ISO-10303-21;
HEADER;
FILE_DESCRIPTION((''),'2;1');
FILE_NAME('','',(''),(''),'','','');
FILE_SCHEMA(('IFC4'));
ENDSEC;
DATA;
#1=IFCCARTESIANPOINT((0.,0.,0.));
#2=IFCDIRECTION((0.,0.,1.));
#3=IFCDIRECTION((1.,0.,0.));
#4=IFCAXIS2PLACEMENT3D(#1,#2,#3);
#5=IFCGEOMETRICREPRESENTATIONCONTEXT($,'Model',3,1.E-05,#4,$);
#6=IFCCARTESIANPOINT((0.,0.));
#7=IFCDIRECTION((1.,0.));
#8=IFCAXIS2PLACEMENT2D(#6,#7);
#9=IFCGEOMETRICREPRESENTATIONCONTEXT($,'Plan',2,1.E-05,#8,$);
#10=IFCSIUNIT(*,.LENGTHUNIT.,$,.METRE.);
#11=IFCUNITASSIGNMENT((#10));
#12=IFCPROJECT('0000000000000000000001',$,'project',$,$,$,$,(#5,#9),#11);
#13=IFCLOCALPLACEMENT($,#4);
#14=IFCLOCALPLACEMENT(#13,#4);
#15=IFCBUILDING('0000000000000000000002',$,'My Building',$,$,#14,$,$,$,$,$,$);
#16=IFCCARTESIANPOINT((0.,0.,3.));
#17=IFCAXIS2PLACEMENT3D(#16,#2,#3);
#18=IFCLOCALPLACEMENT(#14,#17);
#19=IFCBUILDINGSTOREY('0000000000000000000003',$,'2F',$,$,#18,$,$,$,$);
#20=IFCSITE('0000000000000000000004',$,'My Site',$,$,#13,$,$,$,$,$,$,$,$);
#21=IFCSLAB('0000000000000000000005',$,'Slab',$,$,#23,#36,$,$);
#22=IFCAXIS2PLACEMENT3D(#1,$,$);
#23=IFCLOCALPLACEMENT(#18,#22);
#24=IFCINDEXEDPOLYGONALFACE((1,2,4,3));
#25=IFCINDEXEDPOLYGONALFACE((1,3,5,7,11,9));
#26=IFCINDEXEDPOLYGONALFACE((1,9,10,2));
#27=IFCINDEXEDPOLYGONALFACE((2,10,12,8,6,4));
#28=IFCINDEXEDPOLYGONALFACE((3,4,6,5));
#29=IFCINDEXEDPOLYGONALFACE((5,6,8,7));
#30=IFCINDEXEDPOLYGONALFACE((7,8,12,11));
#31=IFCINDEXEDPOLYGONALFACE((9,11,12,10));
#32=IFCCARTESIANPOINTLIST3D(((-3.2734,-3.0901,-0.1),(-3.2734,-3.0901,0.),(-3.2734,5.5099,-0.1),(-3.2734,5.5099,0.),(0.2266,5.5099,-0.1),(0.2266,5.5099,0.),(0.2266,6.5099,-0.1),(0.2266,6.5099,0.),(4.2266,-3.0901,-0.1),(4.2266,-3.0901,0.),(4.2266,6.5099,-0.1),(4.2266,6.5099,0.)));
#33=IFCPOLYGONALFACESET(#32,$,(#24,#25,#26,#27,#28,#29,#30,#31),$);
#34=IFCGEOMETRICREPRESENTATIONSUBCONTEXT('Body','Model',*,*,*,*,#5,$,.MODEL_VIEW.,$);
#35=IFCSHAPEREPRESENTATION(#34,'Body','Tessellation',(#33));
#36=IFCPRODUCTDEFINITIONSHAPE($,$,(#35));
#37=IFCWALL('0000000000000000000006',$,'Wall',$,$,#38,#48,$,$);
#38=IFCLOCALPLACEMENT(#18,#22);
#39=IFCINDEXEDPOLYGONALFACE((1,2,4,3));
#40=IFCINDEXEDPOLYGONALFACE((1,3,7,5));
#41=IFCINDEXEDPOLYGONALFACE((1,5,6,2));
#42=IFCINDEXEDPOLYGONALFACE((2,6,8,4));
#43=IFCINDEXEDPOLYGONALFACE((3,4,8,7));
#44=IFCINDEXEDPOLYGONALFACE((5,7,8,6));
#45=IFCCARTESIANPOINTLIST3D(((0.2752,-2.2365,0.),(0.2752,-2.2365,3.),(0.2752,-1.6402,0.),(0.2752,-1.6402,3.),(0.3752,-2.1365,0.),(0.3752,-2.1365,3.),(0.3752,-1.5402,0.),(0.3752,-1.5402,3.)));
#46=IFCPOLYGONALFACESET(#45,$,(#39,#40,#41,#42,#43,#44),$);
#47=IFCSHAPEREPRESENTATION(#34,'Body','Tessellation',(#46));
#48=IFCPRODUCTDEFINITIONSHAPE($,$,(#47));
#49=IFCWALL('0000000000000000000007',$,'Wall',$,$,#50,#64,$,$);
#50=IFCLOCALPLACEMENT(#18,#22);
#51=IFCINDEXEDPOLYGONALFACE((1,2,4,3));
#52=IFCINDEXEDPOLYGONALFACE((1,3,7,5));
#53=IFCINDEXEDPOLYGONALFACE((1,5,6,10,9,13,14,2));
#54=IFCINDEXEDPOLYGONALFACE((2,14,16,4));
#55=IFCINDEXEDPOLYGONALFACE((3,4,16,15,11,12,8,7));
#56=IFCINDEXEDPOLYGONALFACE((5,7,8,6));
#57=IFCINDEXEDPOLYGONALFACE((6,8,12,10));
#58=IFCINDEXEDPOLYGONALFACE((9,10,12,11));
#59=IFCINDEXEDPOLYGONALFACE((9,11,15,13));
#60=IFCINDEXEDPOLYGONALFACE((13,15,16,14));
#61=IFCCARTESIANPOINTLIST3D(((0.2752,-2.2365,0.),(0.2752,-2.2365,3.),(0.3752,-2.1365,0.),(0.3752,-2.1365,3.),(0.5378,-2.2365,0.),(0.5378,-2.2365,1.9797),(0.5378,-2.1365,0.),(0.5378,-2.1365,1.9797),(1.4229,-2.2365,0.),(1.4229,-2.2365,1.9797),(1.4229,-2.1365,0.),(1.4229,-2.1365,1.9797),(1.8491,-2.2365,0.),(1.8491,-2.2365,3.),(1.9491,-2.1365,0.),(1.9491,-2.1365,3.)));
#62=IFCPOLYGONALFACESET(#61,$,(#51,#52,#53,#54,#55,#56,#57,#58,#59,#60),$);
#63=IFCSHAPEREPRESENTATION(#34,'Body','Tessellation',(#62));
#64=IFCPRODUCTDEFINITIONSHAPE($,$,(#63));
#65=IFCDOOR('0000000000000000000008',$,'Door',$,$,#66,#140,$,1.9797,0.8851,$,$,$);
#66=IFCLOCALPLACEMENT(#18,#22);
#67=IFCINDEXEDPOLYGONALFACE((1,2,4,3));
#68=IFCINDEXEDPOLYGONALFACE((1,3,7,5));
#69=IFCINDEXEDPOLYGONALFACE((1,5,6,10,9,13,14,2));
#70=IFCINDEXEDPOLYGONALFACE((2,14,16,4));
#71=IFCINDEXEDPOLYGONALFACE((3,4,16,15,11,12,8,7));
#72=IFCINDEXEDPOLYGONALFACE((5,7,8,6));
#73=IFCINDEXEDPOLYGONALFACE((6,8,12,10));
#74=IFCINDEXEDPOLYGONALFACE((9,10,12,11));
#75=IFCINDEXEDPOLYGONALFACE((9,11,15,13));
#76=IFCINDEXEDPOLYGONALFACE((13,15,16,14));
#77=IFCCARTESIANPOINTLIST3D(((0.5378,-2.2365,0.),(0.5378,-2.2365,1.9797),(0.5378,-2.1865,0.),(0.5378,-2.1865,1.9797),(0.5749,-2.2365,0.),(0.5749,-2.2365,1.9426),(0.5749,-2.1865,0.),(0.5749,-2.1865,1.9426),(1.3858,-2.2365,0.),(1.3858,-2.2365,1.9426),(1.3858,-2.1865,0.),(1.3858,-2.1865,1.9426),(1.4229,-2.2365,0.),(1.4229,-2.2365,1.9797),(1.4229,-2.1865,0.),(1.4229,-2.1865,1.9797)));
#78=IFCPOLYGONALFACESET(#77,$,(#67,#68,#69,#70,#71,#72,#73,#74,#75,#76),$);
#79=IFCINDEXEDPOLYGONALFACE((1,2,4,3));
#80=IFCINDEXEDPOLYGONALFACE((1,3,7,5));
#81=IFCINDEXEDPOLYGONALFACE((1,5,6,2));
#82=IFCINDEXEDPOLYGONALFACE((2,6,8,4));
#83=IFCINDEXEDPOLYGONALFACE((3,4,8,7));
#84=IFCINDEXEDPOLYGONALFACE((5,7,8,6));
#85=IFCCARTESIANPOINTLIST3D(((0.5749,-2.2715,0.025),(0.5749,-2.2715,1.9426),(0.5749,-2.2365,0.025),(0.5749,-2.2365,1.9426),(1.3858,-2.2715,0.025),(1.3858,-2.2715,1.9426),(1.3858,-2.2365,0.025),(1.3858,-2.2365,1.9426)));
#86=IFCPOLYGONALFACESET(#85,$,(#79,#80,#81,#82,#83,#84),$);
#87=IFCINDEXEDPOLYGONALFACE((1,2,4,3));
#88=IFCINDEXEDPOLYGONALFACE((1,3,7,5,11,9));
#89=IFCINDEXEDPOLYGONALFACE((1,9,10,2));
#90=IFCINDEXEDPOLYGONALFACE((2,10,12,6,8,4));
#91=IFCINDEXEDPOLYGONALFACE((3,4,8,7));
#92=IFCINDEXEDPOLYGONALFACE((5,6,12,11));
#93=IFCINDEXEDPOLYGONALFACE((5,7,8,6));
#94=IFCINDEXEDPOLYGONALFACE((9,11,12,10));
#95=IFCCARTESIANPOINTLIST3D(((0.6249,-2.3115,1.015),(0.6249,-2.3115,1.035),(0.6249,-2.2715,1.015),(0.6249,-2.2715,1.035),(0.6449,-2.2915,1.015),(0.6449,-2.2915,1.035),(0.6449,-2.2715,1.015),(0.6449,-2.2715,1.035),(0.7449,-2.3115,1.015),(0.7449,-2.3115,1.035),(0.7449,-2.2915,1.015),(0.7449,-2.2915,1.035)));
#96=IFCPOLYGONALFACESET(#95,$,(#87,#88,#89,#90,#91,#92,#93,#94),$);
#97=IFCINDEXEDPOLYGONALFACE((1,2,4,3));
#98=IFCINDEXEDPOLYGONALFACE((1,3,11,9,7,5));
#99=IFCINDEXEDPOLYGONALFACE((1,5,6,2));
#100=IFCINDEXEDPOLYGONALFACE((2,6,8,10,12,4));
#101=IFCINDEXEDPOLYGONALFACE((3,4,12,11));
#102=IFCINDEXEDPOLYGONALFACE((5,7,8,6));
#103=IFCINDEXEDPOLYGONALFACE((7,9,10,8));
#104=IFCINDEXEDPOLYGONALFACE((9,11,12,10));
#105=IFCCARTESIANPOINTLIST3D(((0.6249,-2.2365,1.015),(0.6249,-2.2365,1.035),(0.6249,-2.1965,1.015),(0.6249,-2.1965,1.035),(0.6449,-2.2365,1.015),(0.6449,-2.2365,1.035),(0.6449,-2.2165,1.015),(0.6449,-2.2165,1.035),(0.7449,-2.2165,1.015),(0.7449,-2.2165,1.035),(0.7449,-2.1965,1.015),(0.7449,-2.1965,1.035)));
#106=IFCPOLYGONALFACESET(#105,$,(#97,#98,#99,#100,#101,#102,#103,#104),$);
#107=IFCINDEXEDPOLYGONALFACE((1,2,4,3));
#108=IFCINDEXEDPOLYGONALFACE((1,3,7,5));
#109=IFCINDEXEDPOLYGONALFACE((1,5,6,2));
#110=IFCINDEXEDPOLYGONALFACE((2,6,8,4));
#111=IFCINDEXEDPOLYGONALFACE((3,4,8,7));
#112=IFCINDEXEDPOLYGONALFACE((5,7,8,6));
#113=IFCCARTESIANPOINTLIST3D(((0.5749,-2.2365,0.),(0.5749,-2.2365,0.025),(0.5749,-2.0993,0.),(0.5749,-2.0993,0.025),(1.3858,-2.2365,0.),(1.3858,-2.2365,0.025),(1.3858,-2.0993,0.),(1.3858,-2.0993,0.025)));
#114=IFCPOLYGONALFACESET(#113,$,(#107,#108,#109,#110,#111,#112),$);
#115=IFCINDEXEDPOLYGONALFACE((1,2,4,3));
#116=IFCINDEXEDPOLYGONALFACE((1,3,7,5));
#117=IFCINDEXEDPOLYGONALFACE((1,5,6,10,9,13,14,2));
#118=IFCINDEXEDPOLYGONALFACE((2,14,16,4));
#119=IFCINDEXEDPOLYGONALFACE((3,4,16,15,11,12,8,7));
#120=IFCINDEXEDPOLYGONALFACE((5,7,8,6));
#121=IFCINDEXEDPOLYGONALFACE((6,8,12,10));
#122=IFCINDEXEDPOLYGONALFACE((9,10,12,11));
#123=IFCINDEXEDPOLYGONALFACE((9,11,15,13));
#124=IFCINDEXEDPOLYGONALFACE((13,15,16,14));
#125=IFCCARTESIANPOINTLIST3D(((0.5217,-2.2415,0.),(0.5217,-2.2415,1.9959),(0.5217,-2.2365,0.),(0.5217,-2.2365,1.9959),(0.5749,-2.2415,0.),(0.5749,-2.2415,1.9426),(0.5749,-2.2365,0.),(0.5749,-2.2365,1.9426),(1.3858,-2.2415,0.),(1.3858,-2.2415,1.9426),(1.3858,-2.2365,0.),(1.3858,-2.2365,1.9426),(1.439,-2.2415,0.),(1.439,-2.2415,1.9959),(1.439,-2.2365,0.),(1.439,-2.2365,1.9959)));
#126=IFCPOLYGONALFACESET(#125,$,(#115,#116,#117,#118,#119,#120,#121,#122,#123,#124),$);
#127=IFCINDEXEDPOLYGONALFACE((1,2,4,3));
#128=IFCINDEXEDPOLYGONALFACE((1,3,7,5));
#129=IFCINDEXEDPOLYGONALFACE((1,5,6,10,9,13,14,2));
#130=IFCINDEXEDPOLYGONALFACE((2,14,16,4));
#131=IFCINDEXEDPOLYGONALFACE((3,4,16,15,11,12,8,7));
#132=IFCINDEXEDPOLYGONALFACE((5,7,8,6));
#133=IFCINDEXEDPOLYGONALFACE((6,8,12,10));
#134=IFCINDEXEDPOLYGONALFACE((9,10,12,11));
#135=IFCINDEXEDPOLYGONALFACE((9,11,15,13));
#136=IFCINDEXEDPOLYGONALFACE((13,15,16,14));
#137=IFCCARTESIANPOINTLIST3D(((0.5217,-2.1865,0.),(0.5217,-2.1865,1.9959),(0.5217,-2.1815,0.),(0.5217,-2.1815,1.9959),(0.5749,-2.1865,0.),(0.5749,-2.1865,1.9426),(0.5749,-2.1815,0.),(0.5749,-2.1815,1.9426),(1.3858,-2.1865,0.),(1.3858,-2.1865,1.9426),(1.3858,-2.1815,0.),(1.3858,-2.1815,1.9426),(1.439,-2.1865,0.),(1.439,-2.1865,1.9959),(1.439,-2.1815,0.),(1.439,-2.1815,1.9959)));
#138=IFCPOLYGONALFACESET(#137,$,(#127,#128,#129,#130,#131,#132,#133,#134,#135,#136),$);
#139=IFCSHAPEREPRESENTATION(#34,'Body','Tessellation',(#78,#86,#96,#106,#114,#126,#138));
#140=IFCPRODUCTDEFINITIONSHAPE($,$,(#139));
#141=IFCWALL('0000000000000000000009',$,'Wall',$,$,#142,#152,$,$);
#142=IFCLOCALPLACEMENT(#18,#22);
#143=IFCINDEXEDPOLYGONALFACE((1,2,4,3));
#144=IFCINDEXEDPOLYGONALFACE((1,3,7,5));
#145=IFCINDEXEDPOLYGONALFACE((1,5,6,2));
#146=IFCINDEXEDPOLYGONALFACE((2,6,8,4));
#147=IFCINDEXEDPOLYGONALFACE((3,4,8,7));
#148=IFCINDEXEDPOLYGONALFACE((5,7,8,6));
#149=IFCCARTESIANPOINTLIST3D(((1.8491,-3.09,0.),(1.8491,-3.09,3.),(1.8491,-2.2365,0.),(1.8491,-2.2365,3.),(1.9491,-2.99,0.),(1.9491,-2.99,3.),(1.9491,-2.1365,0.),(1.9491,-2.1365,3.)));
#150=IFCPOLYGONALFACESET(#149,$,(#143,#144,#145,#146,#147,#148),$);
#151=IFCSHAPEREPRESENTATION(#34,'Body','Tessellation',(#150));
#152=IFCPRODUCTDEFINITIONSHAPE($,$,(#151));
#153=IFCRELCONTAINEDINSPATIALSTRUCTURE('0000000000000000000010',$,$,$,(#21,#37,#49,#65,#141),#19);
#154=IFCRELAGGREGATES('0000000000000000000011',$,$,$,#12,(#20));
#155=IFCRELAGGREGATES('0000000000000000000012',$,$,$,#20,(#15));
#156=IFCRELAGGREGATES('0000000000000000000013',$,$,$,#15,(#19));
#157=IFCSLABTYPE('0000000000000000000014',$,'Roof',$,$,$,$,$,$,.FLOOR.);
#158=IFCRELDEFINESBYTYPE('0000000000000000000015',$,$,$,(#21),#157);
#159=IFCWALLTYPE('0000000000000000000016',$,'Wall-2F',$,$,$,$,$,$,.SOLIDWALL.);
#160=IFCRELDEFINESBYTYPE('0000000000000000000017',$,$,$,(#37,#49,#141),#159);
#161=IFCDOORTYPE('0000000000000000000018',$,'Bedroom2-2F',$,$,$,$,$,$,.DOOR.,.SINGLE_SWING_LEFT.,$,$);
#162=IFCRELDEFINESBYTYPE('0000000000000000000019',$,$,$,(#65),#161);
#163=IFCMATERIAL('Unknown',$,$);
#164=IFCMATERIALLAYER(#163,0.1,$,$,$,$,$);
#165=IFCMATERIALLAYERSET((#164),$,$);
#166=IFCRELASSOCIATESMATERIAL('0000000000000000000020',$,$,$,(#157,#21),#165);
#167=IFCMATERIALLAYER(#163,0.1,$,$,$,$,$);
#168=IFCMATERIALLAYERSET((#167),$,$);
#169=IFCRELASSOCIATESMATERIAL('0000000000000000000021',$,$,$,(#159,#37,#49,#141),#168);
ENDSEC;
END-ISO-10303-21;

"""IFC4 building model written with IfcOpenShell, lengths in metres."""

from ifc_helpers import new_model, entity, si_unit, frame, origin_with_axes, origin_2d_with_axis, place, context, subcontext, project, spatial, line, indexed_curve, outline, extrude, shape, source, transform, mapped, material, layer, layer_set, layer_usage, type_object, type_shapes, element, fill, save


model = new_model("IFC4")

# Units and contexts
model_context = context("Model", 3, precision=1e-05, world=origin_with_axes())
plan_context = context("Plan", 2, precision=1e-05, world=origin_2d_with_axis())
body_context_1 = subcontext(model_context, "Body", "Model", "MODEL_VIEW")
body_context_2 = subcontext(plan_context, "Body", "Plan", "PLAN_VIEW")
ifc_project = project(units=[si_unit("LENGTHUNIT", "METRE")], contexts=[model_context, plan_context])

# Site, building, storey
site_placement = place(None, origin_with_axes())
site = spatial("IfcSite", under=ifc_project, at=site_placement, Name="My Site")
building_placement = place(site_placement, origin_with_axes())
building = spatial("IfcBuilding", under=site, at=building_placement, Name="My Building")
storey_placement = place(building_placement, frame((0.0, 0.0, 3.0), z_axis=(0.0, 0.0, 1.0), x_axis=(1.0, 0.0, 0.0)))
storey = spatial("IfcBuildingStorey", under=building, at=storey_placement, Name="2F")

# Slab
ifc_material = material(Name="Unknown")
ifc_layer_1 = layer(ifc_material, 0.1)
ifc_layer_set_1 = layer_set([ifc_layer_1])
ifc_layer_usage_1 = layer_usage(ifc_layer_set_1, "AXIS3", "POSITIVE", -0.1)
slab_type = type_object("IfcSlabType", Name="Roof", PredefinedType="FLOOR", material=ifc_layer_set_1)
slab_placement = place(storey_placement, frame((4.2266, 6.5099, 0.0), z_axis=(0.0, 0.0, 1.0), x_axis=(1.0, 0.0, 0.0)))
element("IfcSlab", 1, at=slab_placement, inside=storey, type_object=slab_type, material=ifc_layer_usage_1, Name="Slab", context=body_context_1, shape_type="SweptSolid", body=[
    extrude(outline(indexed_curve([(0.0, 0.0), (-4.0, 0.0), (-4.0, -1.0), (-7.5, -1.0), (-7.5, -9.6), (0.0, -9.6), (0.0, 0.0)])), frame((0.0, 0.0, -0.1), z_axis=(0.0, 0.0, 1.0), x_axis=(1.0, 0.0, 0.0)), (0.0, 0.0, 1.0), 0.1),
])

# Wall
ifc_layer_2 = layer(ifc_material, 0.1)
ifc_layer_set_2 = layer_set([ifc_layer_2])
ifc_layer_usage_2 = layer_usage(ifc_layer_set_2, "AXIS2", "POSITIVE", 0.0)
wall_type = type_object("IfcWallType", Name="Wall-2F", PredefinedType="SOLIDWALL", material=ifc_layer_set_2)
wall_1_placement = place(storey_placement, frame((0.2752, -1.6402, 0.0), z_axis=(0.0, 0.0, 1.0), x_axis=(0.0, -1.0, 0.0)))
element("IfcWall", 2, at=wall_1_placement, inside=storey, type_object=wall_type, material=ifc_layer_usage_2, Name="Wall", context=body_context_1, shape_type="SweptSolid", body=[
    extrude(outline(indexed_curve([(0.0, 0.0), (-0.1, 0.1), (0.4963, 0.1), (0.5963, 0.0)], segments=[line(1, 2, 3, 4, 1)])), origin_with_axes(), (0.0, 0.0, 1.0), 3.0),
])

# Wall, opening, door
ifc_layer_usage_3 = layer_usage(ifc_layer_set_2, "AXIS2", "POSITIVE", 0.0)
wall_2_placement = place(storey_placement, frame((0.2752, -2.2365, 0.0), z_axis=(0.0, 0.0, 1.0), x_axis=(1.0, 0.0, 0.0)))
wall_2 = element("IfcWall", 3, at=wall_2_placement, inside=storey, type_object=wall_type, material=ifc_layer_usage_3, Name="Wall", context=body_context_1, shape_type="SweptSolid", body=[
    extrude(outline(indexed_curve([(0.0, 0.0), (0.1, 0.1), (1.6739, 0.1), (1.5739, 0.0)], segments=[line(1, 2, 3, 4, 1)])), origin_with_axes(), (0.0, 0.0, 1.0), 3.0),
])
shared_shape_1 = source(origin_with_axes(), body_context_1, "Body", "SweptSolid", [
    extrude(outline(indexed_curve([(0.0, 0.0), (0.8851, 0.0), (0.8851, 1.9797), (0.0, 1.9797)], segments=[line(1, 2, 3, 4, 1)])), frame((0.0, -0.6, 0.0), z_axis=(0.0, -1.0, 0.0), x_axis=(1.0, 0.0, 0.0)), (0.0, 0.0, -1.0), 1.2),
])
opening_1_placement = place(wall_2_placement, frame((0.2627, 0.0, 0.0), z_axis=(0.0, 0.0, 1.0), x_axis=(1.0, 0.0, 0.0)))
opening_1 = element("IfcOpeningElement", 4, at=opening_1_placement, cuts=wall_2, PredefinedType="OPENING", context=body_context_1, shape_type="MappedRepresentation", body=[
    mapped(shared_shape_1, transform((0.0, 0.0, 0.0), x_axis=(1.0, 0.0, 0.0), y_axis=(0.0, 1.0, 0.0), z_axis=(0.0, 0.0, 1.0), scale=1.0)),
])
door_type_1 = type_object("IfcDoorType", Name="Bedroom2-2F", OperationType="SINGLE_SWING_LEFT", PredefinedType="DOOR")
shared_shape_2 = source(origin_with_axes(), body_context_1, "Body", "SweptSolid", [
    extrude(outline(indexed_curve([(0.0, 0.0), (0.0, 1.9797), (0.8851, 1.9797), (0.8851, 0.0), (0.848, 0.0), (0.848, 1.9426), (0.0371, 1.9426), (0.0371, 0.0)], segments=[line(1, 2, 3, 4, 5, 6, 7, 8, 1)])), frame((0.0, 0.0, 0.0), z_axis=(0.0, -1.0, 0.0), x_axis=(1.0, 0.0, 0.0)), (0.0, 0.0, -1.0), 0.05),
    extrude(outline(indexed_curve([(0.0, 0.0), (0.8109, 0.0), (0.8109, 0.035), (0.0, 0.035)], segments=[line(1, 2, 3, 4, 1)])), frame((0.0371, -0.035, 0.025), z_axis=(0.0, 0.0, 1.0), x_axis=(1.0, 0.0, 0.0)), (0.0, 0.0, 1.0), 1.9176),
    extrude(outline(indexed_curve([(0.0, 0.0), (0.0, -0.04), (0.12, -0.04), (0.12, -0.02), (0.02, -0.02), (0.02, 0.0)], segments=[line(1, 2, 3, 4, 5, 6, 1)])), frame((0.0871, -0.035, 1.015), z_axis=(0.0, 0.0, 1.0), x_axis=(1.0, 0.0, 0.0)), (0.0, 0.0, 1.0), 0.02),
    extrude(outline(indexed_curve([(0.0, 0.0), (0.0, 0.04), (0.12, 0.04), (0.12, 0.02), (0.02, 0.02), (0.02, 0.0)], segments=[line(1, 2, 3, 4, 5, 6, 1)])), frame((0.0871, 0.0, 1.015), z_axis=(0.0, 0.0, 1.0), x_axis=(1.0, 0.0, 0.0)), (0.0, 0.0, 1.0), 0.02),
    extrude(outline(indexed_curve([(0.0, 0.0), (0.8109, 0.0), (0.8109, 0.1372), (0.0, 0.1372)], segments=[line(1, 2, 3, 4, 1)])), frame((0.0371, 0.0, 0.0), z_axis=(0.0, 0.0, 1.0), x_axis=(1.0, 0.0, 0.0)), (0.0, 0.0, 1.0), 0.025),
    extrude(outline(indexed_curve([(0.0, 0.0), (0.0, 1.9959), (0.9174, 1.9959), (0.9174, 0.0), (0.8641, 0.0), (0.8641, 1.9426), (0.0532, 1.9426), (0.0532, 0.0)], segments=[line(1, 2, 3, 4, 5, 6, 7, 8, 1)])), frame((-0.0162, -0.005, 0.0), z_axis=(0.0, -1.0, 0.0), x_axis=(1.0, 0.0, 0.0)), (0.0, 0.0, -1.0), 0.005),
    extrude(outline(indexed_curve([(0.0, 0.0), (0.0, 1.9959), (0.9174, 1.9959), (0.9174, 0.0), (0.8641, 0.0), (0.8641, 1.9426), (0.0532, 1.9426), (0.0532, 0.0)], segments=[line(1, 2, 3, 4, 5, 6, 7, 8, 1)])), frame((-0.0162, 0.05, 0.0), z_axis=(0.0, -1.0, 0.0), x_axis=(1.0, 0.0, 0.0)), (0.0, 0.0, -1.0), 0.005),
])
shared_shape_3 = source(origin_with_axes(), body_context_2, "Body", "Curve2D", [
    entity("IfcIndexedPolyCurve", entity("IfcCartesianPointList2D", [[0.0, 0.0], [0.0371, 0.0], [0.0371, 0.05], [0.0, 0.05]]), [entity("IfcLineIndex", [1, 2, 3, 4, 1])]),
    entity("IfcIndexedPolyCurve", entity("IfcCartesianPointList2D", [[0.8851, 0.0], [0.848, 0.0], [0.848, 0.05], [0.8851, 0.05]]), [entity("IfcLineIndex", [1, 2, 3, 4, 1])]),
    entity("IfcIndexedPolyCurve", entity("IfcCartesianPointList2D", [[1.2534, -0.035], [0.4425, -0.035], [0.4425, 0.0], [1.2534, 0.0]]), [entity("IfcLineIndex", [1, 2, 3, 4, 1])]),
])
type_shapes(door_type_1, [shared_shape_2, shared_shape_3])
door_1_placement = place(opening_1_placement, frame((0.0, 0.0, 0.0), z_axis=(0.0, 0.0, 1.0), x_axis=(1.0, 0.0, 0.0)))
door_1 = element("IfcDoor", 5, at=door_1_placement, inside=storey, type_object=door_type_1, Name="Door", OverallHeight=1.9797, OverallWidth=0.8851, shapes=[
    shape(body_context_1, "Body", "MappedRepresentation", [mapped(shared_shape_2, transform((0.0, 0.0, 0.0), x_axis=(1.0, 0.0, 0.0), y_axis=(0.0, 1.0, 0.0), z_axis=(0.0, 0.0, 1.0), scale=1.0))]),
    shape(body_context_2, "Body", "MappedRepresentation", [mapped(shared_shape_3, transform((0.0, 0.0, 0.0), x_axis=(1.0, 0.0, 0.0), y_axis=(0.0, 1.0, 0.0), z_axis=(0.0, 0.0, 1.0), scale=1.0))]),
])
fill(opening_1, door_1)

# Wall
ifc_layer_usage_4 = layer_usage(ifc_layer_set_2, "AXIS2", "POSITIVE", 0.0)
wall_3_placement = place(storey_placement, frame((1.8491, -2.2365, 0.0), z_axis=(0.0, 0.0, 1.0), x_axis=(0.0, -1.0, 0.0)))
element("IfcWall", 6, at=wall_3_placement, inside=storey, type_object=wall_type, material=ifc_layer_usage_4, Name="Wall", context=body_context_1, shape_type="SweptSolid", body=[
    extrude(outline(indexed_curve([(0.0, 0.0), (-0.1, 0.1), (0.7535, 0.1), (0.8535, 0.0)], segments=[line(1, 2, 3, 4, 1)])), origin_with_axes(), (0.0, 0.0, 1.0), 3.0),
])

save(model, "model.ifc")
